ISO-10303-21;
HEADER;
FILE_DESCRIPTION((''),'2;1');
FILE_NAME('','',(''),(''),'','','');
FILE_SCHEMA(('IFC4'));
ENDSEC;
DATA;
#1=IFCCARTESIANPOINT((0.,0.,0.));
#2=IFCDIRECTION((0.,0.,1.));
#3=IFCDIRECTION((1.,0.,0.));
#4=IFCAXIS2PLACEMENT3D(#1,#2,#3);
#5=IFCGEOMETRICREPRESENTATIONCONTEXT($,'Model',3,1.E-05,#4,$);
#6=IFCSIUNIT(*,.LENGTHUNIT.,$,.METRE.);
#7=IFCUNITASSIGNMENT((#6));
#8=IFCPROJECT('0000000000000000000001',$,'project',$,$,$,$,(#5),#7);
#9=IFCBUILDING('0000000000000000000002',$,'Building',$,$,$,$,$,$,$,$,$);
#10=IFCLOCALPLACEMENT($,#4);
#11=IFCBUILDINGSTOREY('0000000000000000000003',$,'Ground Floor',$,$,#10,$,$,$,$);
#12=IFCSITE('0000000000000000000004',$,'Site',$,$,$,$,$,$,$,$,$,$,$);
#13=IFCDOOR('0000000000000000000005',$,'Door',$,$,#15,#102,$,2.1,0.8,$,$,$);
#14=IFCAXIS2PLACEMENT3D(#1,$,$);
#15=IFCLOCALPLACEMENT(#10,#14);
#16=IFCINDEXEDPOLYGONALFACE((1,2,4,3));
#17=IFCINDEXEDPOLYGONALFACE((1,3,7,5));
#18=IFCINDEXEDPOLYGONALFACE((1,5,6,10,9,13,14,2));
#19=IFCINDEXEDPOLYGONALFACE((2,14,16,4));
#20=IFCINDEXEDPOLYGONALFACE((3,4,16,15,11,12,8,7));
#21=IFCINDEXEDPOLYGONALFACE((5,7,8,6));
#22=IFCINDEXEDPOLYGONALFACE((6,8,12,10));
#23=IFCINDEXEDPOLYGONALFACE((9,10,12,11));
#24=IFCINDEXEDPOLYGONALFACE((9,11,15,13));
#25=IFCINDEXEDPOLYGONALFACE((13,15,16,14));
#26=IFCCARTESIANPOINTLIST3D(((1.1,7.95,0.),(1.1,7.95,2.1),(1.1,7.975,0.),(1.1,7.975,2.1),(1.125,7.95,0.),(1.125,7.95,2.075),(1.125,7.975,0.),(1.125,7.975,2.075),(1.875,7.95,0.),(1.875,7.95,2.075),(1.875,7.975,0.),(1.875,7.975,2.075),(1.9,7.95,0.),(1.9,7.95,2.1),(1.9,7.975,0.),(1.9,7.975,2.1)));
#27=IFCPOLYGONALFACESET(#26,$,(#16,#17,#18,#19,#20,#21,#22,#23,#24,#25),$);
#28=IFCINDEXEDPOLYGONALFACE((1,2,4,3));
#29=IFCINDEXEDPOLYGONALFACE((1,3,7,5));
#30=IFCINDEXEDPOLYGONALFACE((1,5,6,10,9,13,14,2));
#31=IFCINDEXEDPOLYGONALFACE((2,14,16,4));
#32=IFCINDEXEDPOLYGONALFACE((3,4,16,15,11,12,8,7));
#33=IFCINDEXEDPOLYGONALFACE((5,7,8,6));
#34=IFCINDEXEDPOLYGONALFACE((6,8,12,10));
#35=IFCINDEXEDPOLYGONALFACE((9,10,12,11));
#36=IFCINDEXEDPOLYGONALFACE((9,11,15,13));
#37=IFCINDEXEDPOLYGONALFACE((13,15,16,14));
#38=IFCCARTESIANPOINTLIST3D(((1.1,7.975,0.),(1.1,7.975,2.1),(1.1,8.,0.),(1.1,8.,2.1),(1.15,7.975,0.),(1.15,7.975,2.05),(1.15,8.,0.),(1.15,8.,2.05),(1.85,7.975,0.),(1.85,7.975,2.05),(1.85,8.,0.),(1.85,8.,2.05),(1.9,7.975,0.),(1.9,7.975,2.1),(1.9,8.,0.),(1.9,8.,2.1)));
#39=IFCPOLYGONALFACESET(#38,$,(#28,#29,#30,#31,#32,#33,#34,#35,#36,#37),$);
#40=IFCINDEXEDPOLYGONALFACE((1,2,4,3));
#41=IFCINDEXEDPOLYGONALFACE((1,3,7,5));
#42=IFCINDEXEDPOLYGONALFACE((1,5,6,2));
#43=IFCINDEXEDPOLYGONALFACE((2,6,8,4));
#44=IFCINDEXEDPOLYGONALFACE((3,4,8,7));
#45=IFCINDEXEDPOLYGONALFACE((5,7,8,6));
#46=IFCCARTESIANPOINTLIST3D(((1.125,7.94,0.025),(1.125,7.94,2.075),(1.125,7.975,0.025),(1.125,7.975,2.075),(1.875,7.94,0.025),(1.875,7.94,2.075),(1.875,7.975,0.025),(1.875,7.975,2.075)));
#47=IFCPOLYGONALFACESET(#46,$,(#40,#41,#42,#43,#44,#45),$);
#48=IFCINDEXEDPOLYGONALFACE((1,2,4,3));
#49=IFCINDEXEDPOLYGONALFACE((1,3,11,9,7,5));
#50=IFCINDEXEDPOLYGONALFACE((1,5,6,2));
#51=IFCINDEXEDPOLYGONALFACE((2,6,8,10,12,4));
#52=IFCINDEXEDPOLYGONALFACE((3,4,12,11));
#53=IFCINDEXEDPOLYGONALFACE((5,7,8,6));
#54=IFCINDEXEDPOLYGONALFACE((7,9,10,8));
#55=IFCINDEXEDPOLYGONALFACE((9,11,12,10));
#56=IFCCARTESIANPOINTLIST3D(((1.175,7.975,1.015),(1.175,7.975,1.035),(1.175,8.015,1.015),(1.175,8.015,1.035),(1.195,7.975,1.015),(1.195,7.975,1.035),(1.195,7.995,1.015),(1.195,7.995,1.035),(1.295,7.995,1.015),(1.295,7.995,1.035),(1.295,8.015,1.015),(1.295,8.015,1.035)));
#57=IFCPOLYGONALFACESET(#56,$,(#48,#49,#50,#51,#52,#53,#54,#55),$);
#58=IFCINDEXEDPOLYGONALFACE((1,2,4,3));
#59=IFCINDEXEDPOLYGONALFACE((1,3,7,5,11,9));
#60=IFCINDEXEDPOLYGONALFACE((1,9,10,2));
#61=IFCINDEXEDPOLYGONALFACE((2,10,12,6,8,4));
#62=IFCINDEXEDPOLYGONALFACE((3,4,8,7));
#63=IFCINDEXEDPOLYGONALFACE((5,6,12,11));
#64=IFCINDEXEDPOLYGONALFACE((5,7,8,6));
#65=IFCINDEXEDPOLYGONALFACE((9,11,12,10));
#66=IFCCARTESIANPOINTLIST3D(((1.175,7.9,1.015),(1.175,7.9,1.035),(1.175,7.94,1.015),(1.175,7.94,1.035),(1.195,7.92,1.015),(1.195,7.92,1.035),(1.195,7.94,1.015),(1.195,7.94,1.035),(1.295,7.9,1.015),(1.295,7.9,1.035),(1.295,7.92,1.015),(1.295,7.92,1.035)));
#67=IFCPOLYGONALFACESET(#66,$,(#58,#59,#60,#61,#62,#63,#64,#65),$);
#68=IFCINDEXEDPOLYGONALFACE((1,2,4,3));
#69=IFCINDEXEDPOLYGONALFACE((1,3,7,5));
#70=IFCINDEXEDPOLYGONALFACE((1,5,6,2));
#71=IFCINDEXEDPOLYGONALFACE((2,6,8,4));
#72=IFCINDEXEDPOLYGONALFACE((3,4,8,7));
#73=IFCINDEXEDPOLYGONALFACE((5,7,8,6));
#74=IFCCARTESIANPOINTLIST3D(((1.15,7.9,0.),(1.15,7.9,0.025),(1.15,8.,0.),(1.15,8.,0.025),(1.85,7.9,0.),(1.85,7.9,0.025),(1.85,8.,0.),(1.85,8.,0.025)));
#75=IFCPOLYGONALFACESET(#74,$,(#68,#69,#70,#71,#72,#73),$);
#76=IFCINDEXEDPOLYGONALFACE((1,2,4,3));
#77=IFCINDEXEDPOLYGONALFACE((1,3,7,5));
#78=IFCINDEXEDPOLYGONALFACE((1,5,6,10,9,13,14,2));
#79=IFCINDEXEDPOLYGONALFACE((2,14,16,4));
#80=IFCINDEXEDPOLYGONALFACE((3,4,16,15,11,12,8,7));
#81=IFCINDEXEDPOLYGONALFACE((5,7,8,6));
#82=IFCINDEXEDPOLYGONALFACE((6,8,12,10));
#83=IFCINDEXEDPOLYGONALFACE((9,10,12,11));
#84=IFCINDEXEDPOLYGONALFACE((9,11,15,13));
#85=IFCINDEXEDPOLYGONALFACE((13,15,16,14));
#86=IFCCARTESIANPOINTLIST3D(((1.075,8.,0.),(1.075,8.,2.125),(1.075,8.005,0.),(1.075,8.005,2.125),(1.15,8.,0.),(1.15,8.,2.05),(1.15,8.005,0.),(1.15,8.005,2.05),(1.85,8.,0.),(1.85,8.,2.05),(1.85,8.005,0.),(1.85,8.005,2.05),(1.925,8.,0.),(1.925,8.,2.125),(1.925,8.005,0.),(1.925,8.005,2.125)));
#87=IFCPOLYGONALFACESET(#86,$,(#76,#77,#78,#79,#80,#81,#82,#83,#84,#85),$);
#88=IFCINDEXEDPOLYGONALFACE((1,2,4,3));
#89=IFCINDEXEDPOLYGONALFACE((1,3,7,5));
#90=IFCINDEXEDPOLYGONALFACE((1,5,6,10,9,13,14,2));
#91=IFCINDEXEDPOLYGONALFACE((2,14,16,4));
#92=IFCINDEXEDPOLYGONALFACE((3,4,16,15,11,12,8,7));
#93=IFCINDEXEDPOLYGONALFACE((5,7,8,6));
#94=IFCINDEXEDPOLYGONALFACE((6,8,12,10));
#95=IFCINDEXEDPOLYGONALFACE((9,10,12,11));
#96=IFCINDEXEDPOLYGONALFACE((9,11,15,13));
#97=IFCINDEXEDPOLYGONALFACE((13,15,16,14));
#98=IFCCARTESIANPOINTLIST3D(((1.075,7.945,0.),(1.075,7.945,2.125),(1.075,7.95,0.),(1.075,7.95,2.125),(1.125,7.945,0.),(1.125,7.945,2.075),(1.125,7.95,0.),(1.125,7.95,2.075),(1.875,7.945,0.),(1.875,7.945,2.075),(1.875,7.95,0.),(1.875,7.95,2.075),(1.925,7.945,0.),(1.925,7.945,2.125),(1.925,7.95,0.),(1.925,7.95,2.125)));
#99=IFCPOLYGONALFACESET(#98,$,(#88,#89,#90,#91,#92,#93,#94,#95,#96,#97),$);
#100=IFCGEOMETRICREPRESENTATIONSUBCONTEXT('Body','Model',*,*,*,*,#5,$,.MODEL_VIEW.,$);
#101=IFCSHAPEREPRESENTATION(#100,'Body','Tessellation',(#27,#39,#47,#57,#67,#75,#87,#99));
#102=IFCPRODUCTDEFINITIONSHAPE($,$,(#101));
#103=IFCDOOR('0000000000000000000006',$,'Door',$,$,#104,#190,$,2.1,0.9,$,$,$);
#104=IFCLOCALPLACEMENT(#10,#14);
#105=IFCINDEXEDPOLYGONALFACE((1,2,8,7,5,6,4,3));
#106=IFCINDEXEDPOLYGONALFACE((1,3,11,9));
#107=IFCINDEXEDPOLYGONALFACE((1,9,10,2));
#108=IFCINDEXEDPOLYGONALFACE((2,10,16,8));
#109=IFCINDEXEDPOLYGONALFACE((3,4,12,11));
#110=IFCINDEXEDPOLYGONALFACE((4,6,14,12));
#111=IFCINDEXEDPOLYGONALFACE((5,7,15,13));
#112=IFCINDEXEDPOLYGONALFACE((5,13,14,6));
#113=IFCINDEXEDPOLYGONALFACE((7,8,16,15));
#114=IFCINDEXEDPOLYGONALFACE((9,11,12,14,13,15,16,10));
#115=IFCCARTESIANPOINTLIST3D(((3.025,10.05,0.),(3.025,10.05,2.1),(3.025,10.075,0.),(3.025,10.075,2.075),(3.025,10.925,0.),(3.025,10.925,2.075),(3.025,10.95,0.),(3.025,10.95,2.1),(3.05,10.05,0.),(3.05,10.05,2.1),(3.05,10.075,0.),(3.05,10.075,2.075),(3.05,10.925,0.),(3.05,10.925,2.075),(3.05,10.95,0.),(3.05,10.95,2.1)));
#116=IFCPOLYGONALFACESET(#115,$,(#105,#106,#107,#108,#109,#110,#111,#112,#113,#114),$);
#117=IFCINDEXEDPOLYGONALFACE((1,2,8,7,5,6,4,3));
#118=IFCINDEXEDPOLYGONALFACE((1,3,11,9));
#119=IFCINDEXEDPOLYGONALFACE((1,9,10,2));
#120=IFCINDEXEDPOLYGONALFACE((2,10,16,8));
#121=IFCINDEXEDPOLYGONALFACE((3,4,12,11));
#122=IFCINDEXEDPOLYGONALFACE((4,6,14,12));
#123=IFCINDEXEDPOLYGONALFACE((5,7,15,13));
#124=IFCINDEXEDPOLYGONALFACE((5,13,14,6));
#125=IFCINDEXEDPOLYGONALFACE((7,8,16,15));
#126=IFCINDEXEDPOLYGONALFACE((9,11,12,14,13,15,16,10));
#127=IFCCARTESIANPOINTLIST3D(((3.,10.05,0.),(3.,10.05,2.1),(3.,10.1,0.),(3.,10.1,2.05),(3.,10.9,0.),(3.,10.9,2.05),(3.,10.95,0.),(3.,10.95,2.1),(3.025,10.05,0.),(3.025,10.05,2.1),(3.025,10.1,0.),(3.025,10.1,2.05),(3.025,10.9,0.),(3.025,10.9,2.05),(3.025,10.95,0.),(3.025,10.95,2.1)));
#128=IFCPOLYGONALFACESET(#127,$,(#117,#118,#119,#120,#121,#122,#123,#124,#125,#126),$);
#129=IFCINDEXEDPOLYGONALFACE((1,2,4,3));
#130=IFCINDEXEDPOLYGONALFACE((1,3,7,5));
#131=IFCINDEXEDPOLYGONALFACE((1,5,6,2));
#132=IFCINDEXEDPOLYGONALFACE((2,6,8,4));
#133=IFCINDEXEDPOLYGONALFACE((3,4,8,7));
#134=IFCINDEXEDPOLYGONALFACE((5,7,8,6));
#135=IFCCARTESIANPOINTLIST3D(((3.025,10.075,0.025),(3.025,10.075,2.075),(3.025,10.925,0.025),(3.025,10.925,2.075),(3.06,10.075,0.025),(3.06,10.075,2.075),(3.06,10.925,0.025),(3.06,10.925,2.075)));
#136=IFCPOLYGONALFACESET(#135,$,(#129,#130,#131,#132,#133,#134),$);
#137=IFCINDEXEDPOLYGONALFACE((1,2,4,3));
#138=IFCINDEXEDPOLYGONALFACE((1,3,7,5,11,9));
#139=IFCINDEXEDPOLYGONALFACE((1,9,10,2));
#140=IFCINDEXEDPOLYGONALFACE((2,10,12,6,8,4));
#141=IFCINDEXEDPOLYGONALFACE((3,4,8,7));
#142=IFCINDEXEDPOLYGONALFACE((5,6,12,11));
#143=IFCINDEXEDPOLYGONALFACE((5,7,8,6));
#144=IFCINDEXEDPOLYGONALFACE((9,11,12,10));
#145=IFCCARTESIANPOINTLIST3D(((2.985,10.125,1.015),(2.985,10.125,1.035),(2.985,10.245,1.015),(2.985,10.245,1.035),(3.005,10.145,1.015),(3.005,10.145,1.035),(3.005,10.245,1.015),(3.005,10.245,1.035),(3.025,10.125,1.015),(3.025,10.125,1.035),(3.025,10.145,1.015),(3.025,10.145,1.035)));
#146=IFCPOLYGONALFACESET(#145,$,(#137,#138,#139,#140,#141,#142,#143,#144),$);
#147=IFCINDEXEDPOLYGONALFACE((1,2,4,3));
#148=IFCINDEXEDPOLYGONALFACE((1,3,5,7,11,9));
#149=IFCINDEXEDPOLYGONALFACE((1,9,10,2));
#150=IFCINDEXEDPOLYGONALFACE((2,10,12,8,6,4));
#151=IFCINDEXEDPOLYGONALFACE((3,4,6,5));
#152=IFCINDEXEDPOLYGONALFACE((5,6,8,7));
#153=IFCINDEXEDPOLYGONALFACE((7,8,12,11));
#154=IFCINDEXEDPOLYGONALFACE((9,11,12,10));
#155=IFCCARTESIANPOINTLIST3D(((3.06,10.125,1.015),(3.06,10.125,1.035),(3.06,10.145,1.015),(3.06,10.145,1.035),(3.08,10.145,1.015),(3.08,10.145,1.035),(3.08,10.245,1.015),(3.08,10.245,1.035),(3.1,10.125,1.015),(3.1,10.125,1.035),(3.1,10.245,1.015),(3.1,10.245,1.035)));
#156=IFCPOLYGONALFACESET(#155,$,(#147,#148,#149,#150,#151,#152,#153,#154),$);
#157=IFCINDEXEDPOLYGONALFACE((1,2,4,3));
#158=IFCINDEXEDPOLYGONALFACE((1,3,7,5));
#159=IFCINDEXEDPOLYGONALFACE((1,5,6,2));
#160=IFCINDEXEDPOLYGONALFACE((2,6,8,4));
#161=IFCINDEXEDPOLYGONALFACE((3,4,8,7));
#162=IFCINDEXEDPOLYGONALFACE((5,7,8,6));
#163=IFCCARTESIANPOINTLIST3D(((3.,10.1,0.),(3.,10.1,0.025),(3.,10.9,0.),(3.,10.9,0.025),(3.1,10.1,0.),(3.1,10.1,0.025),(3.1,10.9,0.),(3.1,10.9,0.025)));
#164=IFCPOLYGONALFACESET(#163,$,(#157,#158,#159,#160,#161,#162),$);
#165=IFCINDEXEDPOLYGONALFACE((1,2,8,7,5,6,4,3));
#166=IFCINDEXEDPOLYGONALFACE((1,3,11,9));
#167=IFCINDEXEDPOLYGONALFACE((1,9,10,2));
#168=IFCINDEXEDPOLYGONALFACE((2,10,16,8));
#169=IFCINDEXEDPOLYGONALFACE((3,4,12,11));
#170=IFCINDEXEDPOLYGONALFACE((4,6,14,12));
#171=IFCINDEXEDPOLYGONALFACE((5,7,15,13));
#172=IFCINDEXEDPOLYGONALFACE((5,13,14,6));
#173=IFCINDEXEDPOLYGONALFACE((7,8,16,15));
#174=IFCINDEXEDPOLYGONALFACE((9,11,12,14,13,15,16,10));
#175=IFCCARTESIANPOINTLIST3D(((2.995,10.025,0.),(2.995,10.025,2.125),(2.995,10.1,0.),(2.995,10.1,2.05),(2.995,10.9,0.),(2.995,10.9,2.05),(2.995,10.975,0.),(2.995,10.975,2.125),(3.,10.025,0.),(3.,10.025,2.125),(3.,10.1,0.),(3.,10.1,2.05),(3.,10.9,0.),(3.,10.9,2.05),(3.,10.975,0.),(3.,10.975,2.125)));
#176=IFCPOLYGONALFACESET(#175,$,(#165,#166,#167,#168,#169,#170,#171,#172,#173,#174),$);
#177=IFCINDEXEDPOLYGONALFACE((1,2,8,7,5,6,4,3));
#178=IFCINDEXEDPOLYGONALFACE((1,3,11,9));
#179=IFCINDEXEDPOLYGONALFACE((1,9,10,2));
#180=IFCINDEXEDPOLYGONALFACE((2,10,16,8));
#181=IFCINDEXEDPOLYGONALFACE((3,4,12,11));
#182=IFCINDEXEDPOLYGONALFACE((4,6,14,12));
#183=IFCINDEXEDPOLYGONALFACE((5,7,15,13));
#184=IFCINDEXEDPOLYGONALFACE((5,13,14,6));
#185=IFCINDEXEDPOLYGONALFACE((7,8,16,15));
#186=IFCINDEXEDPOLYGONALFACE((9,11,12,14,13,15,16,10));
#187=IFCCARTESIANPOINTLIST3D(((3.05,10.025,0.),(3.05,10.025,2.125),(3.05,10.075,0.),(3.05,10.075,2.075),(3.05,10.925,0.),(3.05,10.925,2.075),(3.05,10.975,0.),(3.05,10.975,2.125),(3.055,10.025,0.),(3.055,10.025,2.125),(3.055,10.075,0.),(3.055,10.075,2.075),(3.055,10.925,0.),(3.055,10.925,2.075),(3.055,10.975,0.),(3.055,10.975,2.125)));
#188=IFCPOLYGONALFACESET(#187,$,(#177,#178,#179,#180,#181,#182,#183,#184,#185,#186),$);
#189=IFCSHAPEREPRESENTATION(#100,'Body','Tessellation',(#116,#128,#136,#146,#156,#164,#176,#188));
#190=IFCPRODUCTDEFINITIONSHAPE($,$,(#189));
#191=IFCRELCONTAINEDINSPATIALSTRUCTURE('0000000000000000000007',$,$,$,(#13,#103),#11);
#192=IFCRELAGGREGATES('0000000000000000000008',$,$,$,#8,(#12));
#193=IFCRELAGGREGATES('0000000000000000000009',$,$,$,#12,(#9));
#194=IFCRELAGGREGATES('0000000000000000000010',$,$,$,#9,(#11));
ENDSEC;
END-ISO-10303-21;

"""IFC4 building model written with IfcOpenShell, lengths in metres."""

from ifc_helpers import new_model, si_unit, frame, origin_with_axes, place, context, subcontext, project, spatial, line, indexed_curve, outline, extrude, element, save


model = new_model("IFC4")

# Units and contexts
model_context = context("Model", 3, precision=1e-05, world=origin_with_axes())
body_context = subcontext(model_context, "Body", "Model", "MODEL_VIEW")
ifc_project = project(units=[si_unit("LENGTHUNIT", "METRE")], contexts=[model_context])

# Site, building, storey
site = spatial("IfcSite", under=ifc_project, Name="Site")
building = spatial("IfcBuilding", under=site, Name="Building")
storey_placement = place(None, origin_with_axes())
storey = spatial("IfcBuildingStorey", under=building, at=storey_placement, Name="Ground Floor")

# Doors
door_1_placement = place(storey_placement, frame((1.9, 8.0, 0.0), z_axis=(0.0, 0.0, 1.0), x_axis=(-1.0, 0.0, 0.0)))
element("IfcDoor", 1, at=door_1_placement, inside=storey, Name="Door", OverallHeight=2.1, OverallWidth=0.8, context=body_context, shape_type="SweptSolid", body=[
    extrude(outline(indexed_curve([(0.0, 0.0), (0.0, 2.1), (0.8, 2.1), (0.8, 0.0), (0.775, 0.0), (0.775, 2.075), (0.025, 2.075), (0.025, 0.0)], segments=[line(1, 2, 3, 4, 5, 6, 7, 8, 1)])), frame((0.0, 0.025, 0.0), z_axis=(0.0, -1.0, 0.0), x_axis=(1.0, 0.0, 0.0)), (0.0, 0.0, -1.0), 0.025),
    extrude(outline(indexed_curve([(0.0, 0.0), (0.0, 2.1), (0.8, 2.1), (0.8, 0.0), (0.75, 0.0), (0.75, 2.05), (0.05, 2.05), (0.05, 0.0)], segments=[line(1, 2, 3, 4, 5, 6, 7, 8, 1)])), frame((0.0, 0.0, 0.0), z_axis=(0.0, -1.0, 0.0), x_axis=(1.0, 0.0, 0.0)), (0.0, 0.0, -1.0), 0.025),
    extrude(outline(indexed_curve([(0.0, 0.0), (0.75, 0.0), (0.75, 0.035), (0.0, 0.035)], segments=[line(1, 2, 3, 4, 1)])), frame((0.025, 0.025, 0.025), z_axis=(0.0, 0.0, 1.0), x_axis=(1.0, 0.0, 0.0)), (0.0, 0.0, 1.0), 2.05),
    extrude(outline(indexed_curve([(0.0, 0.0), (0.0, -0.04), (-0.12, -0.04), (-0.12, -0.02), (-0.02, -0.02), (-0.02, 0.0)], segments=[line(1, 2, 3, 4, 5, 6, 1)])), frame((0.725, 0.025, 1.015), z_axis=(0.0, 0.0, 1.0), x_axis=(1.0, 0.0, 0.0)), (0.0, 0.0, 1.0), 0.02),
    extrude(outline(indexed_curve([(0.0, 0.0), (0.0, 0.04), (-0.12, 0.04), (-0.12, 0.02), (-0.02, 0.02), (-0.02, 0.0)], segments=[line(1, 2, 3, 4, 5, 6, 1)])), frame((0.725, 0.06, 1.015), z_axis=(0.0, 0.0, 1.0), x_axis=(1.0, 0.0, 0.0)), (0.0, 0.0, 1.0), 0.02),
    extrude(outline(indexed_curve([(0.0, 0.0), (0.7, 0.0), (0.7, 0.1), (0.0, 0.1)], segments=[line(1, 2, 3, 4, 1)])), frame((0.05, 0.0, 0.0), z_axis=(0.0, 0.0, 1.0), x_axis=(1.0, 0.0, 0.0)), (0.0, 0.0, 1.0), 0.025),
    extrude(outline(indexed_curve([(0.0, 0.0), (0.0, 2.125), (0.85, 2.125), (0.85, 0.0), (0.775, 0.0), (0.775, 2.05), (0.075, 2.05), (0.075, 0.0)], segments=[line(1, 2, 3, 4, 5, 6, 7, 8, 1)])), frame((-0.025, -0.005, 0.0), z_axis=(0.0, -1.0, 0.0), x_axis=(1.0, 0.0, 0.0)), (0.0, 0.0, -1.0), 0.005),
    extrude(outline(indexed_curve([(0.0, 0.0), (0.0, 2.125), (0.85, 2.125), (0.85, 0.0), (0.8, 0.0), (0.8, 2.075), (0.05, 2.075), (0.05, 0.0)], segments=[line(1, 2, 3, 4, 5, 6, 7, 8, 1)])), frame((-0.025, 0.05, 0.0), z_axis=(0.0, -1.0, 0.0), x_axis=(1.0, 0.0, 0.0)), (0.0, 0.0, -1.0), 0.005),
])
door_2_placement = place(storey_placement, frame((3.0, 10.95, 0.0), z_axis=(0.0, 0.0, 1.0), x_axis=(0.0, -1.0, 0.0)))
element("IfcDoor", 2, at=door_2_placement, inside=storey, Name="Door", OverallHeight=2.1, OverallWidth=0.9, context=body_context, shape_type="SweptSolid", body=[
    extrude(outline(indexed_curve([(0.0, 0.0), (0.0, 2.1), (0.9, 2.1), (0.9, 0.0), (0.875, 0.0), (0.875, 2.075), (0.025, 2.075), (0.025, 0.0)], segments=[line(1, 2, 3, 4, 5, 6, 7, 8, 1)])), frame((0.0, 0.025, 0.0), z_axis=(0.0, -1.0, 0.0), x_axis=(1.0, 0.0, 0.0)), (0.0, 0.0, -1.0), 0.025),
    extrude(outline(indexed_curve([(0.0, 0.0), (0.0, 2.1), (0.9, 2.1), (0.9, 0.0), (0.85, 0.0), (0.85, 2.05), (0.05, 2.05), (0.05, 0.0)], segments=[line(1, 2, 3, 4, 5, 6, 7, 8, 1)])), frame((0.0, 0.0, 0.0), z_axis=(0.0, -1.0, 0.0), x_axis=(1.0, 0.0, 0.0)), (0.0, 0.0, -1.0), 0.025),
    extrude(outline(indexed_curve([(0.0, 0.0), (0.85, 0.0), (0.85, 0.035), (0.0, 0.035)], segments=[line(1, 2, 3, 4, 1)])), frame((0.025, 0.025, 0.025), z_axis=(0.0, 0.0, 1.0), x_axis=(1.0, 0.0, 0.0)), (0.0, 0.0, 1.0), 2.05),
    extrude(outline(indexed_curve([(0.0, 0.0), (0.0, -0.04), (-0.12, -0.04), (-0.12, -0.02), (-0.02, -0.02), (-0.02, 0.0)], segments=[line(1, 2, 3, 4, 5, 6, 1)])), frame((0.825, 0.025, 1.015), z_axis=(0.0, 0.0, 1.0), x_axis=(1.0, 0.0, 0.0)), (0.0, 0.0, 1.0), 0.02),
    extrude(outline(indexed_curve([(0.0, 0.0), (0.0, 0.04), (-0.12, 0.04), (-0.12, 0.02), (-0.02, 0.02), (-0.02, 0.0)], segments=[line(1, 2, 3, 4, 5, 6, 1)])), frame((0.825, 0.06, 1.015), z_axis=(0.0, 0.0, 1.0), x_axis=(1.0, 0.0, 0.0)), (0.0, 0.0, 1.0), 0.02),
    extrude(outline(indexed_curve([(0.0, 0.0), (0.8, 0.0), (0.8, 0.1), (0.0, 0.1)], segments=[line(1, 2, 3, 4, 1)])), frame((0.05, 0.0, 0.0), z_axis=(0.0, 0.0, 1.0), x_axis=(1.0, 0.0, 0.0)), (0.0, 0.0, 1.0), 0.025),
    extrude(outline(indexed_curve([(0.0, 0.0), (0.0, 2.125), (0.95, 2.125), (0.95, 0.0), (0.875, 0.0), (0.875, 2.05), (0.075, 2.05), (0.075, 0.0)], segments=[line(1, 2, 3, 4, 5, 6, 7, 8, 1)])), frame((-0.025, -0.005, 0.0), z_axis=(0.0, -1.0, 0.0), x_axis=(1.0, 0.0, 0.0)), (0.0, 0.0, -1.0), 0.005),
    extrude(outline(indexed_curve([(0.0, 0.0), (0.0, 2.125), (0.95, 2.125), (0.95, 0.0), (0.9, 0.0), (0.9, 2.075), (0.05, 2.075), (0.05, 0.0)], segments=[line(1, 2, 3, 4, 5, 6, 7, 8, 1)])), frame((-0.025, 0.05, 0.0), z_axis=(0.0, -1.0, 0.0), x_axis=(1.0, 0.0, 0.0)), (0.0, 0.0, -1.0), 0.005),
])

save(model, "model.ifc")
